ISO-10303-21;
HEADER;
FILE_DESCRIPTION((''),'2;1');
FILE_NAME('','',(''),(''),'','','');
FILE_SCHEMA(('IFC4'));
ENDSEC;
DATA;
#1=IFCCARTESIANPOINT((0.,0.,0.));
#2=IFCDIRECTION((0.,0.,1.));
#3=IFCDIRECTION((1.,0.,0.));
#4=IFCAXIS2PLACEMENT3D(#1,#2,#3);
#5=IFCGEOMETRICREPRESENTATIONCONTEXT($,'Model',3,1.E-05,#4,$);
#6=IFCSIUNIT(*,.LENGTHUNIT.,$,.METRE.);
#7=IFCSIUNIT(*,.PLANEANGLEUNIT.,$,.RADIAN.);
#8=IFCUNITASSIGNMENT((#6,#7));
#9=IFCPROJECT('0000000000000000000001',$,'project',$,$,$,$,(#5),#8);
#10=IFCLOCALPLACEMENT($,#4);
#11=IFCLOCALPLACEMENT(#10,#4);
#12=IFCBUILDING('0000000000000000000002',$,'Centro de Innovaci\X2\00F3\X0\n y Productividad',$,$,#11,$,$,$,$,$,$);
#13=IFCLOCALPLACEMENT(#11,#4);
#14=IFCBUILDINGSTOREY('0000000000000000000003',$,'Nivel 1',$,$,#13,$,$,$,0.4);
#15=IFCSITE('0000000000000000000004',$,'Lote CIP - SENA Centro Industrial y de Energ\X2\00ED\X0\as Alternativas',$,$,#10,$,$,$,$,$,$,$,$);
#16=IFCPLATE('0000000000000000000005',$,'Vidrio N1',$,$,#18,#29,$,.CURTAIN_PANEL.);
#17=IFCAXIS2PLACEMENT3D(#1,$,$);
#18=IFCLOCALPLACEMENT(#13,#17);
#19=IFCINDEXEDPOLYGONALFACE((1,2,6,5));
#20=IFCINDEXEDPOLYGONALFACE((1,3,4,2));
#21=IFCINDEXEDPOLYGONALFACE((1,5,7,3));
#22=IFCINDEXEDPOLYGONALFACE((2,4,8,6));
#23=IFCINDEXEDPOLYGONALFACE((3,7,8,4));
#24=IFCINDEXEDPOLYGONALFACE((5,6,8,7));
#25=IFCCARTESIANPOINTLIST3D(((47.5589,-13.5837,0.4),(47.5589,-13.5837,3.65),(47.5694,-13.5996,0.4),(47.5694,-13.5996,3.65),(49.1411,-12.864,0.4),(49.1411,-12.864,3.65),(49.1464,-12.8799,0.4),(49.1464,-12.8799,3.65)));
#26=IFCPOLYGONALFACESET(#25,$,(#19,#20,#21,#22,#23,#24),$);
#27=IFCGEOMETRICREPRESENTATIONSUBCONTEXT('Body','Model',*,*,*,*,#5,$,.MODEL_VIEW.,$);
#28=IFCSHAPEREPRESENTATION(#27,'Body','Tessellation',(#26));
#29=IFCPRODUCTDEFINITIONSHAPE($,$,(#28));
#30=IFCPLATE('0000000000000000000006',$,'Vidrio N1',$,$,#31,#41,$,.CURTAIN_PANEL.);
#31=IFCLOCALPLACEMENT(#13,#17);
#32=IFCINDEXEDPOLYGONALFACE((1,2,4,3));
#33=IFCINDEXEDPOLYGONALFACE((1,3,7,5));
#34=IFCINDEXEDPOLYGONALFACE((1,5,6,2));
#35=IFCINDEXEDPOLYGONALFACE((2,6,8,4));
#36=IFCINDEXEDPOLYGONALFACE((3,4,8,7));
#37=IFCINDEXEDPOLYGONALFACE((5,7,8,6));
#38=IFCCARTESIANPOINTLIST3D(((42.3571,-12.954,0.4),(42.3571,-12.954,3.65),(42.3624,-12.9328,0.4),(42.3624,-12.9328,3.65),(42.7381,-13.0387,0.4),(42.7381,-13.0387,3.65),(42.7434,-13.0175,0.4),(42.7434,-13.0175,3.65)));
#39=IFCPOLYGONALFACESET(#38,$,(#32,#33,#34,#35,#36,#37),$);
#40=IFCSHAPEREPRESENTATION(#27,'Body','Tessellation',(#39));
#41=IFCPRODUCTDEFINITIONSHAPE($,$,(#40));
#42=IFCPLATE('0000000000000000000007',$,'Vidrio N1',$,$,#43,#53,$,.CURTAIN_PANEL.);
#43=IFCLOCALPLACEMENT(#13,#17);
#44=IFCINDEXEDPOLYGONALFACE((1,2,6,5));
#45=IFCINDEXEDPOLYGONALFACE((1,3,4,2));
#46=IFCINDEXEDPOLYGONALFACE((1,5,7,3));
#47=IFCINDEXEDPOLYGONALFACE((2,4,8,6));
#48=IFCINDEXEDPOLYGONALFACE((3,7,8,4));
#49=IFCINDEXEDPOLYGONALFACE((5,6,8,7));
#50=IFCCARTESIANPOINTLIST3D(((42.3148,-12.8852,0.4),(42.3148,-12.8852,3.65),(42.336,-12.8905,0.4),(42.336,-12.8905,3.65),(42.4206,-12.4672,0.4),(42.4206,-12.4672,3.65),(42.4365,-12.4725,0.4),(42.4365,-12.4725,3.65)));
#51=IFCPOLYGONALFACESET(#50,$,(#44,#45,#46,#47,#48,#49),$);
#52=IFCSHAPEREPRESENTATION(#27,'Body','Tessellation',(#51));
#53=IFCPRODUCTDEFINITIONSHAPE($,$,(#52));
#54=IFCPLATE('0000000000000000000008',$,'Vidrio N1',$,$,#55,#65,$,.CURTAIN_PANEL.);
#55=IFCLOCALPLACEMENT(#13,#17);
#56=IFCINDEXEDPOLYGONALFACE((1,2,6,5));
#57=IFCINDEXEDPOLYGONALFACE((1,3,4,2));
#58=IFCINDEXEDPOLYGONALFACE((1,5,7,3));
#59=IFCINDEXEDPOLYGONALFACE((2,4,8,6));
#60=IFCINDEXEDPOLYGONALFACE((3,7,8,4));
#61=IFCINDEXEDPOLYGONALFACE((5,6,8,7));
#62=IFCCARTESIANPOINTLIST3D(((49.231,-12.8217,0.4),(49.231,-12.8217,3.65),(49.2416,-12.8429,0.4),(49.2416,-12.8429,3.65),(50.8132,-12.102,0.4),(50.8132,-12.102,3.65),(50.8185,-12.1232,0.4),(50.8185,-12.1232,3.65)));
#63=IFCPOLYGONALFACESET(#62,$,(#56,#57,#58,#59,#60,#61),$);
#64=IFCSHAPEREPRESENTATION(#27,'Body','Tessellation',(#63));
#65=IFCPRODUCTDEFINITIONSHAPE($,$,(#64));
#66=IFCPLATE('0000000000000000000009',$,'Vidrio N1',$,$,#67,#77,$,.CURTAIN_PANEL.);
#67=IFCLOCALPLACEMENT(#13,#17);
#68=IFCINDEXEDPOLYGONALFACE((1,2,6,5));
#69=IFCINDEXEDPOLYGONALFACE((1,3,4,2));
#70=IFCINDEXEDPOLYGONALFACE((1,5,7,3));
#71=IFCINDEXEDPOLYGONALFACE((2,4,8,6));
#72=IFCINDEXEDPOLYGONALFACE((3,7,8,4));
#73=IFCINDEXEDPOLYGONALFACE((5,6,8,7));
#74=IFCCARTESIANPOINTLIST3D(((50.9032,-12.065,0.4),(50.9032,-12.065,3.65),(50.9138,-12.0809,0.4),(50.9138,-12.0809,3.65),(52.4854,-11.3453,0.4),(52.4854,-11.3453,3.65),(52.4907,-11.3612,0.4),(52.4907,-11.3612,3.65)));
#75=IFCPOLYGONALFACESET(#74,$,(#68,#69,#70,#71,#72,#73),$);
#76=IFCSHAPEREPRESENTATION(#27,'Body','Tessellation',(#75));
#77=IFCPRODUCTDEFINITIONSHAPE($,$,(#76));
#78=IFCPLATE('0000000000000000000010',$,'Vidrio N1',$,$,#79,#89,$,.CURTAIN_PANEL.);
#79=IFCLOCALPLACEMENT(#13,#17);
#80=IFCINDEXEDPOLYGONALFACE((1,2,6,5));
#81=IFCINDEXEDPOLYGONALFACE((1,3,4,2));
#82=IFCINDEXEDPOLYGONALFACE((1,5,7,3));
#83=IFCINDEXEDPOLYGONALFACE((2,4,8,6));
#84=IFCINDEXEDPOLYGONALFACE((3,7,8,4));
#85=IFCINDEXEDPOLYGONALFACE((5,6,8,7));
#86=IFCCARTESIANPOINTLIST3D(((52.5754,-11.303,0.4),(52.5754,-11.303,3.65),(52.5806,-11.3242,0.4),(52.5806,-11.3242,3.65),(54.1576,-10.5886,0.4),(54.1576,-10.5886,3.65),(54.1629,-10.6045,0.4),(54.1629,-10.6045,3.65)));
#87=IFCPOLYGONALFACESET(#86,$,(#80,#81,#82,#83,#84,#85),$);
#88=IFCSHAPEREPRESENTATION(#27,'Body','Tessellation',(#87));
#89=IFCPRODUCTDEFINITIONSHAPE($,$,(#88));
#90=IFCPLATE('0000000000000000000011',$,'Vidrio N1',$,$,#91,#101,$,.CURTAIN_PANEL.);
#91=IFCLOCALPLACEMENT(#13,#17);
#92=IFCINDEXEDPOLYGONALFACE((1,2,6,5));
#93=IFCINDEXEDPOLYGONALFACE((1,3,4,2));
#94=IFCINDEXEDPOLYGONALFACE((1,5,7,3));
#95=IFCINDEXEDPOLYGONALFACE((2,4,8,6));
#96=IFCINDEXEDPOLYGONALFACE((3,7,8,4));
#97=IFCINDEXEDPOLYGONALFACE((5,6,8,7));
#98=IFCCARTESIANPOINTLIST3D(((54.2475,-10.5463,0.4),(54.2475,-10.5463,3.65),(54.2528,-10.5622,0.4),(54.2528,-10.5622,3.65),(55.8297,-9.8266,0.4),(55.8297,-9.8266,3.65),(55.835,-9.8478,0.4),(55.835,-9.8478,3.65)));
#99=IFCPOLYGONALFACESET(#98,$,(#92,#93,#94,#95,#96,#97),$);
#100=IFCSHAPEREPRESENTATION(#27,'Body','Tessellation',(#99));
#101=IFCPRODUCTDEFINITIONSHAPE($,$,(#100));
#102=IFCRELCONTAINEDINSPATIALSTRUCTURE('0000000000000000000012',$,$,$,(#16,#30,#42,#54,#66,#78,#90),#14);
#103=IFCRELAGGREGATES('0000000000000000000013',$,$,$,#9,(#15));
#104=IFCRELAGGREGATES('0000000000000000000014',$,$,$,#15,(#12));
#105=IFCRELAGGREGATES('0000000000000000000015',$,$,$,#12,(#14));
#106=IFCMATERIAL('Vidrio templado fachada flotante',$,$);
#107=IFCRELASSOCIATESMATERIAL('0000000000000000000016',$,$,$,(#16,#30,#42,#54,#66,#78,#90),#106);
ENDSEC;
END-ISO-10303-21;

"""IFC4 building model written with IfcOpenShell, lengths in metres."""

from ifc_helpers import new_model, si_unit, frame, origin_with_axes, place, context, subcontext, project, spatial, polyline, outline, extrude, material, element, save


model = new_model("IFC4")

# Units and contexts
model_context = context("Model", 3, precision=1e-05, world=origin_with_axes())
body_context = subcontext(model_context, "Body", "Model", "MODEL_VIEW")
ifc_project = project(units=[si_unit("LENGTHUNIT", "METRE"), si_unit("PLANEANGLEUNIT", "RADIAN")], contexts=[model_context])

# Site, building, storey
site_placement = place(None, origin_with_axes())
site = spatial("IfcSite", under=ifc_project, at=site_placement, Name="Lote CIP - SENA Centro Industrial y de Energías Alternativas")
building_placement = place(site_placement, origin_with_axes())
building = spatial("IfcBuilding", under=site, at=building_placement, Name="Centro de Innovación y Productividad")
storey_placement = place(building_placement, origin_with_axes())
storey = spatial("IfcBuildingStorey", under=building, at=storey_placement, Name="Nivel 1", Elevation=0.4)

# Plates
ifc_material = material(Name="Vidrio templado fachada flotante")
plate_1_placement = place(storey_placement, origin_with_axes())
element("IfcPlate", 1, at=plate_1_placement, inside=storey, material=ifc_material, Name="Vidrio N1", PredefinedType="CURTAIN_PANEL", context=body_context, shape_type="SweptSolid", body=[
    extrude(outline(polyline([(47.5694, -13.5996), (47.5589, -13.5837), (49.1411, -12.864), (49.1464, -12.8799), (47.5694, -13.5996)])), frame((0.0, 0.0, 0.4)), (0.0, 0.0, 1.0), 3.25),
])
plate_2_placement = place(storey_placement, origin_with_axes())
element("IfcPlate", 2, at=plate_2_placement, inside=storey, material=ifc_material, Name="Vidrio N1", PredefinedType="CURTAIN_PANEL", context=body_context, shape_type="SweptSolid", body=[
    extrude(outline(polyline([(42.7434, -13.0175), (42.7381, -13.0387), (42.3571, -12.954), (42.3624, -12.9328), (42.7434, -13.0175)])), frame((0.0, 0.0, 0.4)), (0.0, 0.0, 1.0), 3.25),
])
plate_3_placement = place(storey_placement, origin_with_axes())
element("IfcPlate", 3, at=plate_3_placement, inside=storey, material=ifc_material, Name="Vidrio N1", PredefinedType="CURTAIN_PANEL", context=body_context, shape_type="SweptSolid", body=[
    extrude(outline(polyline([(42.4365, -12.4725), (42.336, -12.8905), (42.3148, -12.8852), (42.4206, -12.4672), (42.4365, -12.4725)])), frame((0.0, 0.0, 0.4)), (0.0, 0.0, 1.0), 3.25),
])
plate_4_placement = place(storey_placement, origin_with_axes())
element("IfcPlate", 4, at=plate_4_placement, inside=storey, material=ifc_material, Name="Vidrio N1", PredefinedType="CURTAIN_PANEL", context=body_context, shape_type="SweptSolid", body=[
    extrude(outline(polyline([(49.231, -12.8217), (50.8132, -12.102), (50.8185, -12.1232), (49.2416, -12.8429), (49.231, -12.8217)])), frame((0.0, 0.0, 0.4)), (0.0, 0.0, 1.0), 3.25),
])
plate_5_placement = place(storey_placement, origin_with_axes())
element("IfcPlate", 5, at=plate_5_placement, inside=storey, material=ifc_material, Name="Vidrio N1", PredefinedType="CURTAIN_PANEL", context=body_context, shape_type="SweptSolid", body=[
    extrude(outline(polyline([(50.9138, -12.0809), (50.9032, -12.065), (52.4854, -11.3453), (52.4907, -11.3612), (50.9138, -12.0809)])), frame((0.0, 0.0, 0.4)), (0.0, 0.0, 1.0), 3.25),
])
plate_6_placement = place(storey_placement, origin_with_axes())
element("IfcPlate", 6, at=plate_6_placement, inside=storey, material=ifc_material, Name="Vidrio N1", PredefinedType="CURTAIN_PANEL", context=body_context, shape_type="SweptSolid", body=[
    extrude(outline(polyline([(52.5806, -11.3242), (52.5754, -11.303), (54.1576, -10.5886), (54.1629, -10.6045), (52.5806, -11.3242)])), frame((0.0, 0.0, 0.4)), (0.0, 0.0, 1.0), 3.25),
])
plate_7_placement = place(storey_placement, origin_with_axes())
element("IfcPlate", 7, at=plate_7_placement, inside=storey, material=ifc_material, Name="Vidrio N1", PredefinedType="CURTAIN_PANEL", context=body_context, shape_type="SweptSolid", body=[
    extrude(outline(polyline([(54.2528, -10.5622), (54.2475, -10.5463), (55.8297, -9.8266), (55.835, -9.8478), (54.2528, -10.5622)])), frame((0.0, 0.0, 0.4)), (0.0, 0.0, 1.0), 3.25),
])

save(model, "model.ifc")
